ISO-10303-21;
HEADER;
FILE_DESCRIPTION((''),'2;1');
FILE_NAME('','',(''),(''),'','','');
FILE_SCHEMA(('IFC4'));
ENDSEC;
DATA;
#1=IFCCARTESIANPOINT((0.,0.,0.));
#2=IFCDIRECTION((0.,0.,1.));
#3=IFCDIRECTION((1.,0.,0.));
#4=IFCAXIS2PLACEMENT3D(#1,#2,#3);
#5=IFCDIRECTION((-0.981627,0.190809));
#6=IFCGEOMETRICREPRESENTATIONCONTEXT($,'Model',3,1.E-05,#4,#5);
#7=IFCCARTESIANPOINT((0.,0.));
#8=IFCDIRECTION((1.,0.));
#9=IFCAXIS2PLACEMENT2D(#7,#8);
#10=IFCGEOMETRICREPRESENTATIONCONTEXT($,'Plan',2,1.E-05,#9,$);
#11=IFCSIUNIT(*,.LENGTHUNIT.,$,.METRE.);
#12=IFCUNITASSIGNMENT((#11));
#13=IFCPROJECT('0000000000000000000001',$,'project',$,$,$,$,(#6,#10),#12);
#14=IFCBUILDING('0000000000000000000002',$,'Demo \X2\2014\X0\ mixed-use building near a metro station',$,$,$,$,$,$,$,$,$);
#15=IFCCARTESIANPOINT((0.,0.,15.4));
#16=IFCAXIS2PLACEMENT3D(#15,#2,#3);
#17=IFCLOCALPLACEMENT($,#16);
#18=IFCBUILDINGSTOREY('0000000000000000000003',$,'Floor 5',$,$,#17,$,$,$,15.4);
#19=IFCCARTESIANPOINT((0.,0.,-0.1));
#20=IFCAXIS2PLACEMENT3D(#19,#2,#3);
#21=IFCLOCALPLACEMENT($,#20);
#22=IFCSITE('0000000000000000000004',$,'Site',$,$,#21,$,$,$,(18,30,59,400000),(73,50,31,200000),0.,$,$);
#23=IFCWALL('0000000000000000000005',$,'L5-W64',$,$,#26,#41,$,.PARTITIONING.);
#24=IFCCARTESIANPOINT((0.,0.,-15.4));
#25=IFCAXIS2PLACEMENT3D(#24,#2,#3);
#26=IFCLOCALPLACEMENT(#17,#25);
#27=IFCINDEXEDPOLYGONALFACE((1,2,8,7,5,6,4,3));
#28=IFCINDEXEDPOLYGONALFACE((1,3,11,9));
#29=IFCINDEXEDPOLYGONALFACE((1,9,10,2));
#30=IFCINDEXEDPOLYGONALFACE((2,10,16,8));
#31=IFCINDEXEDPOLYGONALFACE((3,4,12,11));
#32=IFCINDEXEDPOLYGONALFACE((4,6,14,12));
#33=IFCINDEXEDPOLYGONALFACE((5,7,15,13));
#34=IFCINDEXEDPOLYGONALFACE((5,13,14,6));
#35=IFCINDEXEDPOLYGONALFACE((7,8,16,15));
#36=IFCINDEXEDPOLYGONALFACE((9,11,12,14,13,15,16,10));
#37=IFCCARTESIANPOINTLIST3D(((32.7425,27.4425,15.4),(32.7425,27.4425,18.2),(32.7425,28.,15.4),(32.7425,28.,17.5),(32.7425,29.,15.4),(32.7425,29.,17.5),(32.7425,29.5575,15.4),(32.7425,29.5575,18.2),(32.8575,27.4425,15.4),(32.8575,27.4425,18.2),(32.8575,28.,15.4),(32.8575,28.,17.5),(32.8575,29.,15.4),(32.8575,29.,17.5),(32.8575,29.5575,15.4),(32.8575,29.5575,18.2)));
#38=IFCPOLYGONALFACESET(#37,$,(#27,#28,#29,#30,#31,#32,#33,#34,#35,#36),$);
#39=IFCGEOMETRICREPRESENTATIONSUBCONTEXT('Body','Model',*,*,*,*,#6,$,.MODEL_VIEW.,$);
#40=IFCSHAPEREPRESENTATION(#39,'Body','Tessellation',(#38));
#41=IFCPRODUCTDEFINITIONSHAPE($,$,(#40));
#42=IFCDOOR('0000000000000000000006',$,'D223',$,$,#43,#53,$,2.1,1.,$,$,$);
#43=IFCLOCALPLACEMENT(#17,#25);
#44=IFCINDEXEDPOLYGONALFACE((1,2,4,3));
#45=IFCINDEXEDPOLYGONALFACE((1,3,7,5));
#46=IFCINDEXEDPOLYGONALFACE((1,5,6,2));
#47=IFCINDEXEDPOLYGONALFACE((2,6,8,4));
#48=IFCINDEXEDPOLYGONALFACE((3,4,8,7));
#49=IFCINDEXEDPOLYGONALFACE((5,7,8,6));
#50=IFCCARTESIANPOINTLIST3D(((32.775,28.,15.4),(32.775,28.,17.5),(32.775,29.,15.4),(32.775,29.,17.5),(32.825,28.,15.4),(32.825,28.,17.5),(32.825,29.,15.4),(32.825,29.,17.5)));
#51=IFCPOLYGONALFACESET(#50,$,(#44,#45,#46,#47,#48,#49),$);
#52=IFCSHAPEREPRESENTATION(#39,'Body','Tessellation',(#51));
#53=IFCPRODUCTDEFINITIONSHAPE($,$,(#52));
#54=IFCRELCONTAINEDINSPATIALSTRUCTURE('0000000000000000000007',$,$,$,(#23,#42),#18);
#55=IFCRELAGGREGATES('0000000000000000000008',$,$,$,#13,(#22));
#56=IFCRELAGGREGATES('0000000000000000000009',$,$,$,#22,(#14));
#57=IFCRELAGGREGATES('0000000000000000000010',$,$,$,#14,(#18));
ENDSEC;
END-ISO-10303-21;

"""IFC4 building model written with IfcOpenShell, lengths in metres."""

from ifc_helpers import new_model, si_unit, direction, frame, origin_with_axes, origin_2d_with_axis, place, context, subcontext, project, spatial, line, indexed_curve, outline, extrude, element, fill, save


model = new_model("IFC4")

# Units and contexts
model_context = context("Model", 3, precision=1e-05, world=origin_with_axes(), true_north=direction((-0.981627, 0.190809)))
plan_context = context("Plan", 2, precision=1e-05, world=origin_2d_with_axis())
body_context = subcontext(model_context, "Body", "Model", "MODEL_VIEW")
ifc_project = project(units=[si_unit("LENGTHUNIT", "METRE")], contexts=[model_context, plan_context])

# Site, building, storey
site_placement = place(None, frame((0.0, 0.0, -0.1), z_axis=(0.0, 0.0, 1.0), x_axis=(1.0, 0.0, 0.0)))
site = spatial("IfcSite", under=ifc_project, at=site_placement, Name="Site", RefLatitude=(18, 30, 59, 400000), RefLongitude=(73, 50, 31, 200000), RefElevation=0.0)
building = spatial("IfcBuilding", under=site, Name="Demo — mixed-use building near a metro station")
storey_placement = place(None, frame((0.0, 0.0, 15.4), z_axis=(0.0, 0.0, 1.0), x_axis=(1.0, 0.0, 0.0)))
storey = spatial("IfcBuildingStorey", under=building, at=storey_placement, Name="Floor 5", Elevation=15.4)

# Wall, opening, door
wall_1_placement = place(storey_placement, frame((0.0, 0.0, -15.4), z_axis=(0.0, 0.0, 1.0), x_axis=(1.0, 0.0, 0.0)))
wall_1 = element("IfcWall", 1, at=wall_1_placement, inside=storey, Name="L5-W64", PredefinedType="PARTITIONING", context=body_context, shape_type="SweptSolid", body=[
    extrude(outline(indexed_curve([(32.8575, 29.5575), (32.8575, 27.4425), (32.7425, 27.4425), (32.7425, 29.5575)], segments=[line(1, 2, 3, 4, 1)])), frame((0.0, 0.0, 15.4), z_axis=(0.0, 0.0, 1.0), x_axis=(1.0, 0.0, 0.0)), (0.0, 0.0, 1.0), 2.8),
])
opening_1_placement = place(wall_1_placement, origin_with_axes())
opening_1 = element("IfcOpeningElement", 2, at=opening_1_placement, cuts=wall_1, context=body_context, shape_type="SweptSolid", body=[
    extrude(outline(indexed_curve([(32.9075, 29.0), (32.9075, 28.0), (32.6925, 28.0), (32.6925, 29.0)], segments=[line(1, 2, 3, 4, 1)])), frame((0.0, 0.0, 15.4), z_axis=(0.0, 0.0, 1.0), x_axis=(1.0, 0.0, 0.0)), (0.0, 0.0, 1.0), 2.1),
])
door_1_placement = place(storey_placement, frame((0.0, 0.0, -15.4), z_axis=(0.0, 0.0, 1.0), x_axis=(1.0, 0.0, 0.0)))
door_1 = element("IfcDoor", 3, at=door_1_placement, inside=storey, Name="D223", OverallHeight=2.1, OverallWidth=1.0, context=body_context, shape_type="SweptSolid", body=[
    extrude(outline(indexed_curve([(32.825, 29.0), (32.825, 28.0), (32.775, 28.0), (32.775, 29.0)], segments=[line(1, 2, 3, 4, 1)])), frame((0.0, 0.0, 15.4), z_axis=(0.0, 0.0, 1.0), x_axis=(1.0, 0.0, 0.0)), (0.0, 0.0, 1.0), 2.1),
])
fill(opening_1, door_1)

save(model, "model.ifc")
